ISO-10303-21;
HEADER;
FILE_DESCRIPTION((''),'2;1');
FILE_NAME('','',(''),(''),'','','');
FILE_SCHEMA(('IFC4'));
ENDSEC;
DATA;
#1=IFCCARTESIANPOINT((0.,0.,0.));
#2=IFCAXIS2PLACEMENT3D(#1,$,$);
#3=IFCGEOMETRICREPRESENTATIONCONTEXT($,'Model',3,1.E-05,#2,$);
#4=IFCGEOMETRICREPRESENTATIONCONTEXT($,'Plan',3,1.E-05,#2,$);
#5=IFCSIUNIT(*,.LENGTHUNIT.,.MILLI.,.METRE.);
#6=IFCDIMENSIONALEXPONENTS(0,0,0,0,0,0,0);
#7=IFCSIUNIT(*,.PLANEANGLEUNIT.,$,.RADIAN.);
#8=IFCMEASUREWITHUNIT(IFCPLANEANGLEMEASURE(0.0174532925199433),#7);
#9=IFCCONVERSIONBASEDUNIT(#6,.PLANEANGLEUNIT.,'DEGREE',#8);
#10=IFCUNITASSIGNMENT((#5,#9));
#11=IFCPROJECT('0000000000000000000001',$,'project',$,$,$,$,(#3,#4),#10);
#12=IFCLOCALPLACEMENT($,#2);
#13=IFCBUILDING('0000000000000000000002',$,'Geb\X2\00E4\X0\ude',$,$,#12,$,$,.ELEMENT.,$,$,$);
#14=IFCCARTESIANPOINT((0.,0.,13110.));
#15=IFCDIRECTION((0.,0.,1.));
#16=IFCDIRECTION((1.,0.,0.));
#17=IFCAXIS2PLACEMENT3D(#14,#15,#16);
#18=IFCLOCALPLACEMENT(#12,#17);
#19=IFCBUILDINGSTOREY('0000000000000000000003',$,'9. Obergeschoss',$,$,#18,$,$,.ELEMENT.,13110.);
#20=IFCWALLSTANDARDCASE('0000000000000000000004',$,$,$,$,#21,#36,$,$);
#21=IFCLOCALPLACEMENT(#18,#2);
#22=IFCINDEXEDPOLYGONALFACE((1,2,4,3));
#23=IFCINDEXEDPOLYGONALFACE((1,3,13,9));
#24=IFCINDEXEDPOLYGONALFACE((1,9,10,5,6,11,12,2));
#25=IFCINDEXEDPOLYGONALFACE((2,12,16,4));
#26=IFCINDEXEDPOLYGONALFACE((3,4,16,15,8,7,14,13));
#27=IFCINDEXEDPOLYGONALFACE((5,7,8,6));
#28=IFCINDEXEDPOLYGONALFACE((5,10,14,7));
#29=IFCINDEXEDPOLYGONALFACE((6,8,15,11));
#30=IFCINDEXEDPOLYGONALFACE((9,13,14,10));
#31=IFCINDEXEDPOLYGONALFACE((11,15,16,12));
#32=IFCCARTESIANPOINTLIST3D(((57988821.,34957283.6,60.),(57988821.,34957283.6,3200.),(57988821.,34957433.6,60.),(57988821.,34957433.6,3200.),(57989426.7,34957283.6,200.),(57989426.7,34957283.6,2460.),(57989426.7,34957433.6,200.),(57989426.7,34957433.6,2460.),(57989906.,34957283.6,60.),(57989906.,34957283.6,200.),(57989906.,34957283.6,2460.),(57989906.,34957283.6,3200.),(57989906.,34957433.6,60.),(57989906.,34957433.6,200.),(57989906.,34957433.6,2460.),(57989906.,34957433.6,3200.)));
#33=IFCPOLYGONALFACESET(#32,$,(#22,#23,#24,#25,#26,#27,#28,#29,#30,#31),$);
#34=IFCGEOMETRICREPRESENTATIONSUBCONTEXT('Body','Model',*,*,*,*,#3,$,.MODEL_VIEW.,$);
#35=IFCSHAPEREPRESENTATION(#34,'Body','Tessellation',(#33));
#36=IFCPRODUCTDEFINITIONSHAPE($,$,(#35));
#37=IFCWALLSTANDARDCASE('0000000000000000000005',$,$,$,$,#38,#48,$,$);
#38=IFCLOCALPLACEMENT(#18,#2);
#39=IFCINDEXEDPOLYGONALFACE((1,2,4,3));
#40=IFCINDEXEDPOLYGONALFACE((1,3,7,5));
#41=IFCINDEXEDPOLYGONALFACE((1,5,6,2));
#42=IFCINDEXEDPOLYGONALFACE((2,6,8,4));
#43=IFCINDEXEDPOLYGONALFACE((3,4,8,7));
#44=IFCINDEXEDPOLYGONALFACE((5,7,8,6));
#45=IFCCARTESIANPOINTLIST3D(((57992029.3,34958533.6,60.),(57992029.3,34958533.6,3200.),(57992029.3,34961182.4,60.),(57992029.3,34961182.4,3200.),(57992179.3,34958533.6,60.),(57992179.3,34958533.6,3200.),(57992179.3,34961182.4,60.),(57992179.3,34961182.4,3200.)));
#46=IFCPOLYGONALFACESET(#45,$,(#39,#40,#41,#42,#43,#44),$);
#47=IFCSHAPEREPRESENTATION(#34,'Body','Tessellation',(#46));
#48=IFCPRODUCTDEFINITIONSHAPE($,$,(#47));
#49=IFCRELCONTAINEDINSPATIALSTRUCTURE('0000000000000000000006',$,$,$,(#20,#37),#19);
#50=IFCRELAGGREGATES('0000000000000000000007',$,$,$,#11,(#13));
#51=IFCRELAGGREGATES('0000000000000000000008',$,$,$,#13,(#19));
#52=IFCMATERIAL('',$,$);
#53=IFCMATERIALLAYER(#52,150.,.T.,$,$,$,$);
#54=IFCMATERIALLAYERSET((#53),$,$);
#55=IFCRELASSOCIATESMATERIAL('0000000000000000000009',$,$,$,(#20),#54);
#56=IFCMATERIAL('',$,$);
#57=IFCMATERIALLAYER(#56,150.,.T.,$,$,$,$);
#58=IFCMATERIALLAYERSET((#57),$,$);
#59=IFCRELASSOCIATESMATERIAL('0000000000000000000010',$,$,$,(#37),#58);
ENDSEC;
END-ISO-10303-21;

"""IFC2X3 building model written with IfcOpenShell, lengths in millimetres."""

from ifc_helpers import new_model, entity, si_unit, converted_unit, frame, frame_2d, origin, origin_with_axes, place, context, subcontext, project, spatial, rectangle, extrude, material, layer, layer_set, layer_usage, element, save


model = new_model("IFC2X3")

# Units and contexts
model_context = context("Model", 3, precision=1e-05, world=origin())
plan_context = context("Plan", 3, precision=1e-05, world=origin())
body_context = subcontext(model_context, "Body", "Model", "MODEL_VIEW")
ifc_project = project(units=[si_unit("LENGTHUNIT", "METRE", prefix="MILLI"), converted_unit("PLANEANGLEUNIT", "DEGREE", entity("IfcPlaneAngleMeasure", 0.0174532925199433), si_unit("PLANEANGLEUNIT", "RADIAN"), dimensions=[0, 0, 0, 0, 0, 0, 0])], contexts=[model_context, plan_context])

# Building, storey
building_placement = place(None, origin())
building = spatial("IfcBuilding", under=ifc_project, at=building_placement, Name="Gebäude", CompositionType="ELEMENT")
storey_placement = place(building_placement, frame((0.0, 0.0, 13110.0), z_axis=(0.0, 0.0, 1.0), x_axis=(1.0, 0.0, 0.0)))
storey = spatial("IfcBuildingStorey", under=building, at=storey_placement, Name="9. Obergeschoss", CompositionType="ELEMENT", Elevation=13110.0)

# Wall, opening
ifc_material_1 = material(Name="")
ifc_layer_1 = layer(ifc_material_1, 150.0, ventilated=True)
ifc_layer_set_1 = layer_set([ifc_layer_1])
ifc_layer_usage_1 = layer_usage(ifc_layer_set_1, "AXIS2", "POSITIVE", 0.0)
wall_1_placement = place(storey_placement, frame((57989906.0, 34957433.6, 60.0), z_axis=(0.0, 0.0, 1.0), x_axis=(-1.0, 0.0, 0.0)))
wall_1 = element("IfcWallStandardCase", 1, at=wall_1_placement, inside=storey, material=ifc_layer_usage_1, context=body_context, shape_type="SweptSolid", body=[
    extrude(rectangle(XDim=1085.0, YDim=150.0, at=frame_2d((542.5, 75.0), x_axis=(1.0, 0.0))), origin_with_axes(), (0.0, 0.0, 1.0), 3140.0),
])
opening_placement = place(wall_1_placement, frame((-280.7, 0.0, 140.0), z_axis=(0.0, 1.0, 0.0), x_axis=(0.0, 0.0, 1.0)))
element("IfcOpeningElement", 2, at=opening_placement, cuts=wall_1, ObjectType="Opening", context=body_context, shape_type="SweptSolid", body=[
    extrude(rectangle(XDim=2260.0, YDim=760.0, at=frame_2d((1130.0, 380.0), x_axis=(1.0, 0.0))), origin_with_axes(), (0.0, 0.0, 1.0), 150.0),
])

# Wall
ifc_material_2 = material(Name="")
ifc_layer_2 = layer(ifc_material_2, 150.0, ventilated=True)
ifc_layer_set_2 = layer_set([ifc_layer_2])
ifc_layer_usage_2 = layer_usage(ifc_layer_set_2, "AXIS2", "POSITIVE", 0.0)
wall_2_placement = place(storey_placement, frame((57992029.3, 34961182.4, 60.0), z_axis=(0.0, 0.0, 1.0), x_axis=(0.0, -1.0, 0.0)))
element("IfcWallStandardCase", 3, at=wall_2_placement, inside=storey, material=ifc_layer_usage_2, context=body_context, shape_type="SweptSolid", body=[
    extrude(rectangle(XDim=2648.9, YDim=150.0, at=frame_2d((1324.4, 75.0), x_axis=(1.0, 0.0))), origin_with_axes(), (0.0, 0.0, 1.0), 3140.0),
])

save(model, "model.ifc")
